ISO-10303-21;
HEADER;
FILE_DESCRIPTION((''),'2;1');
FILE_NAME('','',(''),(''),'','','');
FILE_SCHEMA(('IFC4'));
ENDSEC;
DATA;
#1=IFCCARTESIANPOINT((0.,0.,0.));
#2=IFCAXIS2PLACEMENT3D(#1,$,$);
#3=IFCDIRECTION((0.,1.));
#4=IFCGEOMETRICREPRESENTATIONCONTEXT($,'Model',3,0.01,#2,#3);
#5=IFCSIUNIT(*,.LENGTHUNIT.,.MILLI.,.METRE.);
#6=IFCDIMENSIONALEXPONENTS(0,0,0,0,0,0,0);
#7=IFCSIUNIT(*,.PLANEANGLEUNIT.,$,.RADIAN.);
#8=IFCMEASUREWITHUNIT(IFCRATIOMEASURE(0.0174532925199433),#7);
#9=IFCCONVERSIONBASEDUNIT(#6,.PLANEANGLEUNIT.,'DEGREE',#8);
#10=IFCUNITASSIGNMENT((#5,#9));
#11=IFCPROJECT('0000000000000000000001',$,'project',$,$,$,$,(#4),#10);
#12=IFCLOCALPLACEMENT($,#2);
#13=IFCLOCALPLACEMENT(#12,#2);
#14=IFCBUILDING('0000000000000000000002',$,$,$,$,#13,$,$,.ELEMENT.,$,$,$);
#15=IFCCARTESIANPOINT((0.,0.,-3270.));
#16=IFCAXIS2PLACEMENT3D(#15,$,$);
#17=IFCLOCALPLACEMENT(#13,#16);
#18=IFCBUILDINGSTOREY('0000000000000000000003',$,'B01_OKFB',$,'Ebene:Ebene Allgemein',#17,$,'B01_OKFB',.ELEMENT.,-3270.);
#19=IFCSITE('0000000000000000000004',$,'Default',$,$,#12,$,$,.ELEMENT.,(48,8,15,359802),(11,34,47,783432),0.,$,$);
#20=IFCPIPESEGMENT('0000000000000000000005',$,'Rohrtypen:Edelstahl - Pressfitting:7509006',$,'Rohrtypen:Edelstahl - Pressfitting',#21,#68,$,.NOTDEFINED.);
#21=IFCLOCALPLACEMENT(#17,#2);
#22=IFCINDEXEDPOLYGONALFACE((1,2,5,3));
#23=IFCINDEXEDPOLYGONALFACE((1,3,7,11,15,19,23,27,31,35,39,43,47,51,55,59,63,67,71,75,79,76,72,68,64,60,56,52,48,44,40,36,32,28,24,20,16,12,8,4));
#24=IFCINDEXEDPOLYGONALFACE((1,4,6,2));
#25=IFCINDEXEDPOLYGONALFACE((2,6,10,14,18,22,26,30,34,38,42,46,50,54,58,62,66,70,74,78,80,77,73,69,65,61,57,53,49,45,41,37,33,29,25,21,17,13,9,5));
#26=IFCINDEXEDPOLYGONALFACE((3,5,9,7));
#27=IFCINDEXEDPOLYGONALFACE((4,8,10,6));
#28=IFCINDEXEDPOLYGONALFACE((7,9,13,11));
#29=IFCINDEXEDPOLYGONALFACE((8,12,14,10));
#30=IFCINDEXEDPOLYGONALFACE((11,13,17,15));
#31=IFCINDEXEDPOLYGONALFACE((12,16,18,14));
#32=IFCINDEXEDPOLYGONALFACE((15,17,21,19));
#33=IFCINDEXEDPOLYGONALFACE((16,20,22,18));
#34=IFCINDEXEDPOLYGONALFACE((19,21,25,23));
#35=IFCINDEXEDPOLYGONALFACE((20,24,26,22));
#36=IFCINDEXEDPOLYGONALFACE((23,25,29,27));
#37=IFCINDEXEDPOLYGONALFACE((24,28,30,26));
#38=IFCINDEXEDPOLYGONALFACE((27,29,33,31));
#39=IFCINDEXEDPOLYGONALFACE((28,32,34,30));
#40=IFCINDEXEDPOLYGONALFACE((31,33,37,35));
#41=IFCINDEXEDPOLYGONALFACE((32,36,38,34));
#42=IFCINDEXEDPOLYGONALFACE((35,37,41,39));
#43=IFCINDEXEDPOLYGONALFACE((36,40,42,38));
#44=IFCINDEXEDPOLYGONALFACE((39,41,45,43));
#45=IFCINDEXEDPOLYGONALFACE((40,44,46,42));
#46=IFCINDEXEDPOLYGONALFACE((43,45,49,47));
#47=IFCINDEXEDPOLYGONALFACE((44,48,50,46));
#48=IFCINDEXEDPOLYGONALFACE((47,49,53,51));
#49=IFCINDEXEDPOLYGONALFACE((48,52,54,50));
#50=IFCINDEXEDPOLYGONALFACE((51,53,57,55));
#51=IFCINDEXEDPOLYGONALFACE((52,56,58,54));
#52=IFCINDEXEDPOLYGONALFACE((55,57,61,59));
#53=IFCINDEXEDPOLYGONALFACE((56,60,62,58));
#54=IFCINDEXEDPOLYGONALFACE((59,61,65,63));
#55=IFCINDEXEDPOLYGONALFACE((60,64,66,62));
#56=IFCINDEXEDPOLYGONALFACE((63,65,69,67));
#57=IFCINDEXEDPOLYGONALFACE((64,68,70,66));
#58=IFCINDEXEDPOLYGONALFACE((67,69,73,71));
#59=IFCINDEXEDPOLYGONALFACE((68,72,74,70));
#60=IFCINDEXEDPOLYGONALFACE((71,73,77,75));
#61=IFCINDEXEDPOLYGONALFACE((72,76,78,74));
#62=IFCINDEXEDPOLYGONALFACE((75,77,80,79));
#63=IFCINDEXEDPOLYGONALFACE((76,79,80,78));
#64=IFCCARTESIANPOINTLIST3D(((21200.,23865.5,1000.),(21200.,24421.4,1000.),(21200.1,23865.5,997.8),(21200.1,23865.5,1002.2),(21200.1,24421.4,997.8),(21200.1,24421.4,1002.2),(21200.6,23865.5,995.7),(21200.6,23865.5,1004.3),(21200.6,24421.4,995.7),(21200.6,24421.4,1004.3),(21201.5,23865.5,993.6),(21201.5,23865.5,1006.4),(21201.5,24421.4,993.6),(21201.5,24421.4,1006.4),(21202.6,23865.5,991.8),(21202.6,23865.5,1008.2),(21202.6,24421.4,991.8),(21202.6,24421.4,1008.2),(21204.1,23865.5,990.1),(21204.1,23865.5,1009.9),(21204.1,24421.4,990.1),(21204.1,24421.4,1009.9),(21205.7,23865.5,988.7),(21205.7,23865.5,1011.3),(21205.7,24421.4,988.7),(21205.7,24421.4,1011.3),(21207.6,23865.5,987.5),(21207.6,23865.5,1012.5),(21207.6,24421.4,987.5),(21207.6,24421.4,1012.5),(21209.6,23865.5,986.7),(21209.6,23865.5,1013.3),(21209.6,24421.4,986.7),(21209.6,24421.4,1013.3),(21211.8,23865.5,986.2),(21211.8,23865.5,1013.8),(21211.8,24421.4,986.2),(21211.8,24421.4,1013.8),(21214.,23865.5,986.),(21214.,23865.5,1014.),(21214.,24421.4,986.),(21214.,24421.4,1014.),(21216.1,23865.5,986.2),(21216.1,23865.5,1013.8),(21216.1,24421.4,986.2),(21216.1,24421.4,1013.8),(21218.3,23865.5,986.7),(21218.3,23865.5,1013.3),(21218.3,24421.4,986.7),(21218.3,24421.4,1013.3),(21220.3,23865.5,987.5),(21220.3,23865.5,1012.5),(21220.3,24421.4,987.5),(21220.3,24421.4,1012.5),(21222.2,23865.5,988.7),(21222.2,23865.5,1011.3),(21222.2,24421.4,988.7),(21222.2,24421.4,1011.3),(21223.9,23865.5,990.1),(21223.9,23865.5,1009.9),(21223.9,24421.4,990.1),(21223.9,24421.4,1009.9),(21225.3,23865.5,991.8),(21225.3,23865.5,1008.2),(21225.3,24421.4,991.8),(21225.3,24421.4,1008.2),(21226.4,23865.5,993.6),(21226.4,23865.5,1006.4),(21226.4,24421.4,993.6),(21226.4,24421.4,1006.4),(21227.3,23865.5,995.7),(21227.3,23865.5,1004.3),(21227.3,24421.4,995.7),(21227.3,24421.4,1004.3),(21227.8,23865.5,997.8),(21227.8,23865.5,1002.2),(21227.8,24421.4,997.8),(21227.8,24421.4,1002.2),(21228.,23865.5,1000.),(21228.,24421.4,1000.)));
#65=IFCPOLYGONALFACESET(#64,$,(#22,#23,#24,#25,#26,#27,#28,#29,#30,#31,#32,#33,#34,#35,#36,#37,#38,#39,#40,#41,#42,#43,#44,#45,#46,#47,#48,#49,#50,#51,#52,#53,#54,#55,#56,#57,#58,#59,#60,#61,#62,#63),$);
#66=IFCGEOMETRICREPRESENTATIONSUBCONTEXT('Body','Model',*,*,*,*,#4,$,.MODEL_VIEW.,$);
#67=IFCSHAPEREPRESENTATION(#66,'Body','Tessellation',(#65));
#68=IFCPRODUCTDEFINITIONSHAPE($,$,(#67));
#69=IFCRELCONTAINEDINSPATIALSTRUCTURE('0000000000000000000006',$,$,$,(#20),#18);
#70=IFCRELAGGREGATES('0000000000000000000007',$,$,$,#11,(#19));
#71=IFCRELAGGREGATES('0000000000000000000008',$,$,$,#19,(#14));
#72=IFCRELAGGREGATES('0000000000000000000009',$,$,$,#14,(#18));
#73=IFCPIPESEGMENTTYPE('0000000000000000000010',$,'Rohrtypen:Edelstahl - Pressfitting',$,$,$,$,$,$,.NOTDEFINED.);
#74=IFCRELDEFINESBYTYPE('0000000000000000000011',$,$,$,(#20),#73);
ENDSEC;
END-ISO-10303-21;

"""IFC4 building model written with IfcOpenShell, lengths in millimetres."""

from ifc_helpers import new_model, entity, si_unit, converted_unit, direction, frame, origin, place, context, subcontext, project, spatial, indexed_curve, outline, extrude, type_object, element, save


model = new_model("IFC4")

# Units and contexts
model_context = context("Model", 3, precision=0.01, world=origin(), true_north=direction((0.0, 1.0)))
body_context = subcontext(model_context, "Body", "Model", "MODEL_VIEW")
ifc_project = project(units=[si_unit("LENGTHUNIT", "METRE", prefix="MILLI"), converted_unit("PLANEANGLEUNIT", "DEGREE", entity("IfcRatioMeasure", 0.0174532925199433), si_unit("PLANEANGLEUNIT", "RADIAN"), dimensions=[0, 0, 0, 0, 0, 0, 0])], contexts=[model_context])

# Site, building, storey
site_placement = place(None, origin())
site = spatial("IfcSite", under=ifc_project, at=site_placement, Name="Default", CompositionType="ELEMENT", RefLatitude=(48, 8, 15, 359802), RefLongitude=(11, 34, 47, 783432), RefElevation=0.0)
building_placement = place(site_placement, origin())
building = spatial("IfcBuilding", under=site, at=building_placement, CompositionType="ELEMENT")
storey_placement = place(building_placement, frame((0.0, 0.0, -3270.0)))
storey = spatial("IfcBuildingStorey", under=building, at=storey_placement, Name="B01_OKFB", ObjectType="Ebene:Ebene Allgemein", LongName="B01_OKFB", CompositionType="ELEMENT", Elevation=-3270.0)

# Pipe segment
pipe_segment_type_1 = type_object("IfcPipeSegmentType", Name="Rohrtypen:Edelstahl - Pressfitting", PredefinedType="NOTDEFINED")
pipe_segment_1_placement = place(storey_placement, origin())
element("IfcPipeSegment", 1, at=pipe_segment_1_placement, inside=storey, type_object=pipe_segment_type_1, Name="Rohrtypen:Edelstahl - Pressfitting:7509006", ObjectType="Rohrtypen:Edelstahl - Pressfitting", PredefinedType="NOTDEFINED", context=body_context, shape_type="SweptSolid", body=[
    extrude(outline(indexed_curve([(14.0, 0.0), (13.8, 2.2), (13.3, 4.3), (12.5, 6.4), (11.3, 8.2), (9.9, 9.9), (8.2, 11.3), (6.4, 12.5), (4.3, 13.3), (2.2, 13.8), (0.0, 14.0), (-2.2, 13.8), (-4.3, 13.3), (-6.4, 12.5), (-8.2, 11.3), (-9.9, 9.9), (-11.3, 8.2), (-12.5, 6.4), (-13.3, 4.3), (-13.8, 2.2), (-14.0, 0.0), (-13.8, -2.2), (-13.3, -4.3), (-12.5, -6.4), (-11.3, -8.2), (-9.9, -9.9), (-8.2, -11.3), (-6.4, -12.5), (-4.3, -13.3), (-2.2, -13.8), (0.0, -14.0), (2.2, -13.8), (4.3, -13.3), (6.4, -12.5), (8.2, -11.3), (9.9, -9.9), (11.3, -8.2), (12.5, -6.4), (13.3, -4.3), (13.8, -2.2), (14.0, 0.0)], self_intersect=False)), frame((21214.0, 23865.5, 1000.0), z_axis=(0.0, 1.0, 0.0), x_axis=(1.0, 0.0, 0.0)), (0.0, 0.0, 1.0), 555.8),
])

save(model, "model.ifc")
